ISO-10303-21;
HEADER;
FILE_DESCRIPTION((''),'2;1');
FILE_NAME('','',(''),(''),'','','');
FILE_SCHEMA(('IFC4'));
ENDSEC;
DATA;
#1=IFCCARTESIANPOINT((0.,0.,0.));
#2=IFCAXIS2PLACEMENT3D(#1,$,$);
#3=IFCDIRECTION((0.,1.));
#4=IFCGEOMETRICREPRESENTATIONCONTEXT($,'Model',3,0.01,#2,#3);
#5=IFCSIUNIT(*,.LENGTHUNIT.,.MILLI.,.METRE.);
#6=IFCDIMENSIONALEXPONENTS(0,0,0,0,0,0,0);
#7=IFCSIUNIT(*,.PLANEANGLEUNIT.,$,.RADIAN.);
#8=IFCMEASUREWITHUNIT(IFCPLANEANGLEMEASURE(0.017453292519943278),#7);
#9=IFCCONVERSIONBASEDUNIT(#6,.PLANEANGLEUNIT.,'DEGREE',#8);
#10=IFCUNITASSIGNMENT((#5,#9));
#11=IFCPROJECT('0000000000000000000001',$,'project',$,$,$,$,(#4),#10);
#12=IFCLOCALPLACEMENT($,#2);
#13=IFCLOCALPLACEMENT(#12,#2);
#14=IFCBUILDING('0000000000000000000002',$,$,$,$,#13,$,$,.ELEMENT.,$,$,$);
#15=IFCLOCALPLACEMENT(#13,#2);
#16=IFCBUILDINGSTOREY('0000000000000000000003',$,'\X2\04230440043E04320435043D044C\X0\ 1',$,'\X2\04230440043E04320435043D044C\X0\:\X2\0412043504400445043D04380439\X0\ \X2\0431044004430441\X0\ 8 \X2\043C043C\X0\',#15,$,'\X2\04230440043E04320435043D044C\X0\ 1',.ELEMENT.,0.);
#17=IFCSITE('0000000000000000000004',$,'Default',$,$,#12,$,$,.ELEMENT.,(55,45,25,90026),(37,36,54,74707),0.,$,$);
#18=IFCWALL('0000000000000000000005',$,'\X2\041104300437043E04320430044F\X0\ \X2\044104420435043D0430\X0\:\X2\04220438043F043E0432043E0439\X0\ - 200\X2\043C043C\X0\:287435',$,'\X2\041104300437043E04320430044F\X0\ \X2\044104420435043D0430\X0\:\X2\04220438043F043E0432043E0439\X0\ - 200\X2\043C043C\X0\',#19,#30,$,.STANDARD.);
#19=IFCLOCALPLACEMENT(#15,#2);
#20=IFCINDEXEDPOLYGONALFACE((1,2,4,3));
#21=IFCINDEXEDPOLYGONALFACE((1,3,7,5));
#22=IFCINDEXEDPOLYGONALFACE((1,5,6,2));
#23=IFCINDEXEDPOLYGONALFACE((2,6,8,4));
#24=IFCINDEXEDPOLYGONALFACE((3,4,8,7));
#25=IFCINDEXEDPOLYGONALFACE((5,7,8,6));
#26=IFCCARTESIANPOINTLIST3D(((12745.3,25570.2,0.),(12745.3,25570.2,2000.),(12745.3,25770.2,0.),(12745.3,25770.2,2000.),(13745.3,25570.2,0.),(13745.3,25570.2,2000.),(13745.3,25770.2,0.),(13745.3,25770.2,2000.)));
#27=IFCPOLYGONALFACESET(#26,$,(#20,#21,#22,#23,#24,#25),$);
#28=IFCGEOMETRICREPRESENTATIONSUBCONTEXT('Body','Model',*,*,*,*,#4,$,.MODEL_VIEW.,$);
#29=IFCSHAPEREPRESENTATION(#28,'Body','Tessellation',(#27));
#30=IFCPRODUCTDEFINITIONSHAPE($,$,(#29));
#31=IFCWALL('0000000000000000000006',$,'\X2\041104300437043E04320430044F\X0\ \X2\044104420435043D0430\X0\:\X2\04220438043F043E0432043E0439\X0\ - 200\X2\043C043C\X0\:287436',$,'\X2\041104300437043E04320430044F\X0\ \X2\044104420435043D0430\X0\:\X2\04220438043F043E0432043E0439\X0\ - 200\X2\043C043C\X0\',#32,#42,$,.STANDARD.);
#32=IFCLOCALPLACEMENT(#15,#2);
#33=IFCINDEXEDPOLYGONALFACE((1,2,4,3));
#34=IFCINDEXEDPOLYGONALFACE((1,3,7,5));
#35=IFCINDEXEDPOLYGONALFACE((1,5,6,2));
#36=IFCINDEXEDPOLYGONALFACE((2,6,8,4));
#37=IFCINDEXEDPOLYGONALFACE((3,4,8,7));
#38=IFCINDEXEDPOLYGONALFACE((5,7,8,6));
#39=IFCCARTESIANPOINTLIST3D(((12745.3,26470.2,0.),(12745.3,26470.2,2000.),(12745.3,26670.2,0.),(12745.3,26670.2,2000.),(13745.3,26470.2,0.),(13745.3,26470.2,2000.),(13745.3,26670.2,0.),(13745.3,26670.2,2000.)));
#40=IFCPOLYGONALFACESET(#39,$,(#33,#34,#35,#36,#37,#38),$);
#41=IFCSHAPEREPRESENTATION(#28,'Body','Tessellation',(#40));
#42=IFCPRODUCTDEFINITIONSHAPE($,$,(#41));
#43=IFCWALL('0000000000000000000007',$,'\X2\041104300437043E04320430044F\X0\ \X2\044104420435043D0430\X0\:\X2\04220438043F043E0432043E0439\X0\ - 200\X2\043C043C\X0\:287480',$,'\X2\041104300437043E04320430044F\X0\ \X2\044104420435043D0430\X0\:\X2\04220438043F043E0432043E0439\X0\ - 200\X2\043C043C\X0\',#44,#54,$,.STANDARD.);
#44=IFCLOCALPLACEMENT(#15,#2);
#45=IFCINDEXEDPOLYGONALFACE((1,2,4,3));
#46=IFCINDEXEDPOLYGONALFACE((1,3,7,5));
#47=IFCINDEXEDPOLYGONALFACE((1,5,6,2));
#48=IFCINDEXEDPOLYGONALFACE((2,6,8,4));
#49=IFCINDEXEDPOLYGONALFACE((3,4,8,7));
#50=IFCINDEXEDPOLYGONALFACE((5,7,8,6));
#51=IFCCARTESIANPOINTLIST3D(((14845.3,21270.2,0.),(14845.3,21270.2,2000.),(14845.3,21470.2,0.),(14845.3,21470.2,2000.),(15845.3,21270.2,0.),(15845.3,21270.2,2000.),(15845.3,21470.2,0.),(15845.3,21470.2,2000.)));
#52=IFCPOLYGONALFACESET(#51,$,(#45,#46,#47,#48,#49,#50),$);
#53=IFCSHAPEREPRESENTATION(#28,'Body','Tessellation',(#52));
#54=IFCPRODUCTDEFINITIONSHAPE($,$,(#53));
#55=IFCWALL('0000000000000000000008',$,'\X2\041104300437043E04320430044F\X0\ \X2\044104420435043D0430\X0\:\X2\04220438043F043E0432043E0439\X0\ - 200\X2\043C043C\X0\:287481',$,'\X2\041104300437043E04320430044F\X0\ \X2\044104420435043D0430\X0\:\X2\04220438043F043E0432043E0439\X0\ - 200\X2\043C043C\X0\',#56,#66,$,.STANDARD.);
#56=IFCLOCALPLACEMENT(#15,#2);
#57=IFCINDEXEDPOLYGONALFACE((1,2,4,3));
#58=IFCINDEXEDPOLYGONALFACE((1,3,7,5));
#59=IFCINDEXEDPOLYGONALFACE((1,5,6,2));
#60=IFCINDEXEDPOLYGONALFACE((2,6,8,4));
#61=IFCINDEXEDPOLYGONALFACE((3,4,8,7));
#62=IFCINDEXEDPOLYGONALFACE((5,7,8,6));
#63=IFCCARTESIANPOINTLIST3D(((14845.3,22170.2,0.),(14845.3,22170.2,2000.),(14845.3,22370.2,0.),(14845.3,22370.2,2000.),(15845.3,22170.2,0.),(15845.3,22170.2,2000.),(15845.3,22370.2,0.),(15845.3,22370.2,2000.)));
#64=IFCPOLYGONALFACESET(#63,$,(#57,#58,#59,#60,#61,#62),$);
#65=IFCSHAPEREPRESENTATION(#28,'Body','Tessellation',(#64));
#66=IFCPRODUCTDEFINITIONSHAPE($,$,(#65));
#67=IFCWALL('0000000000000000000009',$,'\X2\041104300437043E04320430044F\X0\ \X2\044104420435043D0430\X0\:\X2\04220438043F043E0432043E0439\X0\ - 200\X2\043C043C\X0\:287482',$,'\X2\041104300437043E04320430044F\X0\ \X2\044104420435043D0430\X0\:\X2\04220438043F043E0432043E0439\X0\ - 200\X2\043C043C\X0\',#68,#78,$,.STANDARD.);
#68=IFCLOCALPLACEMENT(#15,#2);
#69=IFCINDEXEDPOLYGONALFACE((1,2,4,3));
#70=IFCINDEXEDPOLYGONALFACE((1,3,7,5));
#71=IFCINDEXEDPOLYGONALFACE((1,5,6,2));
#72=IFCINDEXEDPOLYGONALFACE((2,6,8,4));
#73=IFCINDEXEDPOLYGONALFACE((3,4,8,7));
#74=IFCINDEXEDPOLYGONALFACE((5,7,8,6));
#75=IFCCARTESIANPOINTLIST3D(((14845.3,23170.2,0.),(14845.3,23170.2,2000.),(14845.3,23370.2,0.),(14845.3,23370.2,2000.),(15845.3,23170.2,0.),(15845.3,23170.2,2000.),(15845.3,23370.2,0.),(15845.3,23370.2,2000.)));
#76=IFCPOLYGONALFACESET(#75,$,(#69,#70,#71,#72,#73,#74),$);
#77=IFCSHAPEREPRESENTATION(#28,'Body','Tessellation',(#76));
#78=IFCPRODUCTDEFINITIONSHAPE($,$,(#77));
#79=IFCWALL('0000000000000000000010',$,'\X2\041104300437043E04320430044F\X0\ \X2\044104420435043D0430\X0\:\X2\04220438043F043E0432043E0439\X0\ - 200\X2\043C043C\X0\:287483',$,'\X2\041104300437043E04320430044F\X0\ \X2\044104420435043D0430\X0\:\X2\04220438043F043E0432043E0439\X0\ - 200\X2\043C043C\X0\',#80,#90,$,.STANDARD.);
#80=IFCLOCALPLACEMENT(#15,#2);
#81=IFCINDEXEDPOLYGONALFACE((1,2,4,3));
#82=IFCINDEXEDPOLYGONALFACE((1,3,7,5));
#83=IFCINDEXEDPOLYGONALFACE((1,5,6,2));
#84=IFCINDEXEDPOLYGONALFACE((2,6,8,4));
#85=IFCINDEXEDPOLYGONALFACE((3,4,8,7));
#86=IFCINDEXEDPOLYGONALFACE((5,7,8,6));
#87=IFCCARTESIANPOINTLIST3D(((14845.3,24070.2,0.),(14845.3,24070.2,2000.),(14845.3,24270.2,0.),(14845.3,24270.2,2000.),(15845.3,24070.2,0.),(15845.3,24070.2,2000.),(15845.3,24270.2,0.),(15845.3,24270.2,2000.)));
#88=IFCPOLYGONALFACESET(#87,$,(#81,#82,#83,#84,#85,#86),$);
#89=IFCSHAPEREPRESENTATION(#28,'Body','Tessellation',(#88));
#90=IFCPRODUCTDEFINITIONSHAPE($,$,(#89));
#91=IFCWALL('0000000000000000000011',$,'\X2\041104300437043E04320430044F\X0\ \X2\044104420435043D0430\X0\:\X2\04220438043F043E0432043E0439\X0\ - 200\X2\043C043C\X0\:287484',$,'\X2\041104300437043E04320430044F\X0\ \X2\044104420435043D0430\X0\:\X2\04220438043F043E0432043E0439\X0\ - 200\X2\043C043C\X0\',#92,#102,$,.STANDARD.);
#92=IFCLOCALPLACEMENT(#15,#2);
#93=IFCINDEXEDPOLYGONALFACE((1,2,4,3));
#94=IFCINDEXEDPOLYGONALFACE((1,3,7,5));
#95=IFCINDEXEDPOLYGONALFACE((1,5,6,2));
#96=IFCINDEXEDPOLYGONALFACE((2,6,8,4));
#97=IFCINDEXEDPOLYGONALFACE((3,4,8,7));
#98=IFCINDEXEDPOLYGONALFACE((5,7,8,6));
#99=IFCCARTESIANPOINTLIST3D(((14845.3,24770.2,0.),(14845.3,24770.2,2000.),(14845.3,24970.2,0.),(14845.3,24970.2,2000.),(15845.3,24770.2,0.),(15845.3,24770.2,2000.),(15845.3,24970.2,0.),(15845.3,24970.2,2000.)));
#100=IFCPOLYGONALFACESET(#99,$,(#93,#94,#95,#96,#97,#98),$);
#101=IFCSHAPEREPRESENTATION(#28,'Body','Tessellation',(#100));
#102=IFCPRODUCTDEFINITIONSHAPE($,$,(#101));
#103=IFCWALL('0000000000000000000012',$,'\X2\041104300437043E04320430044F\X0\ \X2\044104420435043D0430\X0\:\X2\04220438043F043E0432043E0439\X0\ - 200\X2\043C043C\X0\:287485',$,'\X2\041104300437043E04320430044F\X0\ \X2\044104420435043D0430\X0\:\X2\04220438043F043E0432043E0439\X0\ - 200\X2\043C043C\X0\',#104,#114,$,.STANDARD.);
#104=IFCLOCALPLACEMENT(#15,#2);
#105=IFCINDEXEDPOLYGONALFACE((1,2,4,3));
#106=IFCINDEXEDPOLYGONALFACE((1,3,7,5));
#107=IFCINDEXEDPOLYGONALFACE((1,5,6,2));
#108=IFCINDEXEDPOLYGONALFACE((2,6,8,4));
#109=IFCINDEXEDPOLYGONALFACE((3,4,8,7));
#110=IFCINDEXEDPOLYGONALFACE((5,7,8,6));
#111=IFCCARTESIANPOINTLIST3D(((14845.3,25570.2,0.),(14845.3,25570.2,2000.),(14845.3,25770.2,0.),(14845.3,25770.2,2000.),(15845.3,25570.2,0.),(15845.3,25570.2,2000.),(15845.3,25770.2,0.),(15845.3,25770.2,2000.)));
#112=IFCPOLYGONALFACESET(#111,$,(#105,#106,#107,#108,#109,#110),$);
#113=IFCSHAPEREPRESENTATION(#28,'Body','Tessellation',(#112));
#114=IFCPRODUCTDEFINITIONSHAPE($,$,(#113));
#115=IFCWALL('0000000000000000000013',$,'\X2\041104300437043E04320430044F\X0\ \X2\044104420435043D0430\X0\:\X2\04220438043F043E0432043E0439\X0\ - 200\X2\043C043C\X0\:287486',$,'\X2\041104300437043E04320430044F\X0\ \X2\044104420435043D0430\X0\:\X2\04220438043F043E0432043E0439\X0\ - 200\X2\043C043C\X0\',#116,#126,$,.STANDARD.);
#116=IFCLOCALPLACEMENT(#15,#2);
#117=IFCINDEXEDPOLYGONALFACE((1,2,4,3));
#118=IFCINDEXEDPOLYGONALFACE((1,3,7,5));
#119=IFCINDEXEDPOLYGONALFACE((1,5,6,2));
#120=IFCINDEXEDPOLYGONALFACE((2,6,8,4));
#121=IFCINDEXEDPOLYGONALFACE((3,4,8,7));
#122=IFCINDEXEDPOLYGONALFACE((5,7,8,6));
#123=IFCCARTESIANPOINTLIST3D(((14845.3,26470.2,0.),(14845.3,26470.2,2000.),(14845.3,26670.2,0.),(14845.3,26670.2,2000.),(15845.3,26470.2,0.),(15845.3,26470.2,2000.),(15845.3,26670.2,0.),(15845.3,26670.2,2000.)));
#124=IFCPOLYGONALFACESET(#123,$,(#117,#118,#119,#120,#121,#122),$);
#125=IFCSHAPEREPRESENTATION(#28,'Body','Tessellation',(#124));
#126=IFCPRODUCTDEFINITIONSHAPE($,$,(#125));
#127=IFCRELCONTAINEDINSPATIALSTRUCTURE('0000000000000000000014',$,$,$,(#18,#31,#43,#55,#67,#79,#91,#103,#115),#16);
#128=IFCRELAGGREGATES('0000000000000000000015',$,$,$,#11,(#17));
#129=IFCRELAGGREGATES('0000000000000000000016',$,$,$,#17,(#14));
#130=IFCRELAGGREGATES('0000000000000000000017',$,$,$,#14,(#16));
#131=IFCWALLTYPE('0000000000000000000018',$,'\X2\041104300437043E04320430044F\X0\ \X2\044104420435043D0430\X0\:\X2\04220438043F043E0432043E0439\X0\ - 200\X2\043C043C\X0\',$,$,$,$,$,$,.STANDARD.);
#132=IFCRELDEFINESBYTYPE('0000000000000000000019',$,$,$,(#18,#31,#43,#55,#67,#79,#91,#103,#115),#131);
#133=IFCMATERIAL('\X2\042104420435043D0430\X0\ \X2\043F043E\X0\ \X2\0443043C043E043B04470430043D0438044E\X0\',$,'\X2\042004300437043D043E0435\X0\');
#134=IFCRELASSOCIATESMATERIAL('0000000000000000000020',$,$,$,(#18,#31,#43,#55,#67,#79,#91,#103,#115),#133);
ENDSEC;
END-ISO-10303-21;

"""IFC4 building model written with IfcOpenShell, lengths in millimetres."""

from ifc_helpers import new_model, entity, si_unit, converted_unit, direction, frame, origin, place, context, subcontext, project, spatial, indexed_curve, outline, extrude, material, type_object, element, save


model = new_model("IFC4")

# Units and contexts
model_context = context("Model", 3, precision=0.01, world=origin(), true_north=direction((0.0, 1.0)))
body_context = subcontext(model_context, "Body", "Model", "MODEL_VIEW")
ifc_project = project(units=[si_unit("LENGTHUNIT", "METRE", prefix="MILLI"), converted_unit("PLANEANGLEUNIT", "DEGREE", entity("IfcPlaneAngleMeasure", 0.017453292519943278), si_unit("PLANEANGLEUNIT", "RADIAN"), dimensions=[0, 0, 0, 0, 0, 0, 0])], contexts=[model_context])

# Site, building, storey
site_placement = place(None, origin())
site = spatial("IfcSite", under=ifc_project, at=site_placement, Name="Default", CompositionType="ELEMENT", RefLatitude=(55, 45, 25, 90026), RefLongitude=(37, 36, 54, 74707), RefElevation=0.0)
building_placement = place(site_placement, origin())
building = spatial("IfcBuilding", under=site, at=building_placement, CompositionType="ELEMENT")
storey_placement = place(building_placement, origin())
storey = spatial("IfcBuildingStorey", under=building, at=storey_placement, Name="Уровень 1", ObjectType="Уровень:Верхний брус 8 мм", LongName="Уровень 1", CompositionType="ELEMENT", Elevation=0.0)

# Walls
ifc_material = material(Name="Стена по умолчанию", Category="Разное")
wall_type = type_object("IfcWallType", Name="Базовая стена:Типовой - 200мм", PredefinedType="STANDARD")
for number, where, name in (
    (1, (12745.3, 25670.2, 0.0), "Базовая стена:Типовой - 200мм:287435"),
    (2, (12745.3, 26570.2, 0.0), "Базовая стена:Типовой - 200мм:287436"),
):
    element("IfcWall", number, at=place(storey_placement, frame(where)), inside=storey, type_object=wall_type, material=ifc_material, Name=name, ObjectType="Базовая стена:Типовой - 200мм", PredefinedType="STANDARD", context=body_context, shape_type="SweptSolid", body=[
        extrude(outline(indexed_curve([(1000.0, 100.0), (0.0, 100.0), (0.0, -100.0), (1000.0, -100.0), (1000.0, 100.0)], self_intersect=False)), origin(), (0.0, 0.0, 1.0), 2000.0),
    ])
wall_1_placement = place(storey_placement, frame((14845.3, 21370.2, 0.0)))
element("IfcWall", 3, at=wall_1_placement, inside=storey, type_object=wall_type, material=ifc_material, Name="Базовая стена:Типовой - 200мм:287480", ObjectType="Базовая стена:Типовой - 200мм", PredefinedType="STANDARD", context=body_context, shape_type="SweptSolid", body=[
    extrude(outline(indexed_curve([(1000.0, 100.0), (0.0, 100.0), (0.0, -100.0), (1000.0, -100.0), (1000.0, 100.0)], self_intersect=False)), origin(), (0.0, 0.0, 1.0), 2000.0),
])
wall_2_placement = place(storey_placement, frame((14845.3, 22270.2, 0.0)))
element("IfcWall", 4, at=wall_2_placement, inside=storey, type_object=wall_type, material=ifc_material, Name="Базовая стена:Типовой - 200мм:287481", ObjectType="Базовая стена:Типовой - 200мм", PredefinedType="STANDARD", context=body_context, shape_type="SweptSolid", body=[
    extrude(outline(indexed_curve([(1000.0, 100.0), (0.0, 100.0), (0.0, -100.0), (1000.0, -100.0), (1000.0, 100.0)], self_intersect=False)), origin(), (0.0, 0.0, 1.0), 2000.0),
])
wall_3_placement = place(storey_placement, frame((14845.3, 23270.2, 0.0)))
element("IfcWall", 5, at=wall_3_placement, inside=storey, type_object=wall_type, material=ifc_material, Name="Базовая стена:Типовой - 200мм:287482", ObjectType="Базовая стена:Типовой - 200мм", PredefinedType="STANDARD", context=body_context, shape_type="SweptSolid", body=[
    extrude(outline(indexed_curve([(1000.0, 100.0), (0.0, 100.0), (0.0, -100.0), (1000.0, -100.0), (1000.0, 100.0)], self_intersect=False)), origin(), (0.0, 0.0, 1.0), 2000.0),
])
wall_4_placement = place(storey_placement, frame((14845.3, 24170.2, 0.0)))
element("IfcWall", 6, at=wall_4_placement, inside=storey, type_object=wall_type, material=ifc_material, Name="Базовая стена:Типовой - 200мм:287483", ObjectType="Базовая стена:Типовой - 200мм", PredefinedType="STANDARD", context=body_context, shape_type="SweptSolid", body=[
    extrude(outline(indexed_curve([(1000.0, 100.0), (0.0, 100.0), (0.0, -100.0), (1000.0, -100.0), (1000.0, 100.0)], self_intersect=False)), origin(), (0.0, 0.0, 1.0), 2000.0),
])
wall_5_placement = place(storey_placement, frame((14845.3, 24870.2, 0.0)))
element("IfcWall", 7, at=wall_5_placement, inside=storey, type_object=wall_type, material=ifc_material, Name="Базовая стена:Типовой - 200мм:287484", ObjectType="Базовая стена:Типовой - 200мм", PredefinedType="STANDARD", context=body_context, shape_type="SweptSolid", body=[
    extrude(outline(indexed_curve([(1000.0, 100.0), (0.0, 100.0), (0.0, -100.0), (1000.0, -100.0), (1000.0, 100.0)], self_intersect=False)), origin(), (0.0, 0.0, 1.0), 2000.0),
])
wall_6_placement = place(storey_placement, frame((14845.3, 25670.2, 0.0)))
element("IfcWall", 8, at=wall_6_placement, inside=storey, type_object=wall_type, material=ifc_material, Name="Базовая стена:Типовой - 200мм:287485", ObjectType="Базовая стена:Типовой - 200мм", PredefinedType="STANDARD", context=body_context, shape_type="SweptSolid", body=[
    extrude(outline(indexed_curve([(1000.0, 100.0), (0.0, 100.0), (0.0, -100.0), (1000.0, -100.0), (1000.0, 100.0)], self_intersect=False)), origin(), (0.0, 0.0, 1.0), 2000.0),
])
wall_7_placement = place(storey_placement, frame((14845.3, 26570.2, 0.0)))
element("IfcWall", 9, at=wall_7_placement, inside=storey, type_object=wall_type, material=ifc_material, Name="Базовая стена:Типовой - 200мм:287486", ObjectType="Базовая стена:Типовой - 200мм", PredefinedType="STANDARD", context=body_context, shape_type="SweptSolid", body=[
    extrude(outline(indexed_curve([(1000.0, 100.0), (0.0, 100.0), (0.0, -100.0), (1000.0, -100.0), (1000.0, 100.0)], self_intersect=False)), origin(), (0.0, 0.0, 1.0), 2000.0),
])

save(model, "model.ifc")
